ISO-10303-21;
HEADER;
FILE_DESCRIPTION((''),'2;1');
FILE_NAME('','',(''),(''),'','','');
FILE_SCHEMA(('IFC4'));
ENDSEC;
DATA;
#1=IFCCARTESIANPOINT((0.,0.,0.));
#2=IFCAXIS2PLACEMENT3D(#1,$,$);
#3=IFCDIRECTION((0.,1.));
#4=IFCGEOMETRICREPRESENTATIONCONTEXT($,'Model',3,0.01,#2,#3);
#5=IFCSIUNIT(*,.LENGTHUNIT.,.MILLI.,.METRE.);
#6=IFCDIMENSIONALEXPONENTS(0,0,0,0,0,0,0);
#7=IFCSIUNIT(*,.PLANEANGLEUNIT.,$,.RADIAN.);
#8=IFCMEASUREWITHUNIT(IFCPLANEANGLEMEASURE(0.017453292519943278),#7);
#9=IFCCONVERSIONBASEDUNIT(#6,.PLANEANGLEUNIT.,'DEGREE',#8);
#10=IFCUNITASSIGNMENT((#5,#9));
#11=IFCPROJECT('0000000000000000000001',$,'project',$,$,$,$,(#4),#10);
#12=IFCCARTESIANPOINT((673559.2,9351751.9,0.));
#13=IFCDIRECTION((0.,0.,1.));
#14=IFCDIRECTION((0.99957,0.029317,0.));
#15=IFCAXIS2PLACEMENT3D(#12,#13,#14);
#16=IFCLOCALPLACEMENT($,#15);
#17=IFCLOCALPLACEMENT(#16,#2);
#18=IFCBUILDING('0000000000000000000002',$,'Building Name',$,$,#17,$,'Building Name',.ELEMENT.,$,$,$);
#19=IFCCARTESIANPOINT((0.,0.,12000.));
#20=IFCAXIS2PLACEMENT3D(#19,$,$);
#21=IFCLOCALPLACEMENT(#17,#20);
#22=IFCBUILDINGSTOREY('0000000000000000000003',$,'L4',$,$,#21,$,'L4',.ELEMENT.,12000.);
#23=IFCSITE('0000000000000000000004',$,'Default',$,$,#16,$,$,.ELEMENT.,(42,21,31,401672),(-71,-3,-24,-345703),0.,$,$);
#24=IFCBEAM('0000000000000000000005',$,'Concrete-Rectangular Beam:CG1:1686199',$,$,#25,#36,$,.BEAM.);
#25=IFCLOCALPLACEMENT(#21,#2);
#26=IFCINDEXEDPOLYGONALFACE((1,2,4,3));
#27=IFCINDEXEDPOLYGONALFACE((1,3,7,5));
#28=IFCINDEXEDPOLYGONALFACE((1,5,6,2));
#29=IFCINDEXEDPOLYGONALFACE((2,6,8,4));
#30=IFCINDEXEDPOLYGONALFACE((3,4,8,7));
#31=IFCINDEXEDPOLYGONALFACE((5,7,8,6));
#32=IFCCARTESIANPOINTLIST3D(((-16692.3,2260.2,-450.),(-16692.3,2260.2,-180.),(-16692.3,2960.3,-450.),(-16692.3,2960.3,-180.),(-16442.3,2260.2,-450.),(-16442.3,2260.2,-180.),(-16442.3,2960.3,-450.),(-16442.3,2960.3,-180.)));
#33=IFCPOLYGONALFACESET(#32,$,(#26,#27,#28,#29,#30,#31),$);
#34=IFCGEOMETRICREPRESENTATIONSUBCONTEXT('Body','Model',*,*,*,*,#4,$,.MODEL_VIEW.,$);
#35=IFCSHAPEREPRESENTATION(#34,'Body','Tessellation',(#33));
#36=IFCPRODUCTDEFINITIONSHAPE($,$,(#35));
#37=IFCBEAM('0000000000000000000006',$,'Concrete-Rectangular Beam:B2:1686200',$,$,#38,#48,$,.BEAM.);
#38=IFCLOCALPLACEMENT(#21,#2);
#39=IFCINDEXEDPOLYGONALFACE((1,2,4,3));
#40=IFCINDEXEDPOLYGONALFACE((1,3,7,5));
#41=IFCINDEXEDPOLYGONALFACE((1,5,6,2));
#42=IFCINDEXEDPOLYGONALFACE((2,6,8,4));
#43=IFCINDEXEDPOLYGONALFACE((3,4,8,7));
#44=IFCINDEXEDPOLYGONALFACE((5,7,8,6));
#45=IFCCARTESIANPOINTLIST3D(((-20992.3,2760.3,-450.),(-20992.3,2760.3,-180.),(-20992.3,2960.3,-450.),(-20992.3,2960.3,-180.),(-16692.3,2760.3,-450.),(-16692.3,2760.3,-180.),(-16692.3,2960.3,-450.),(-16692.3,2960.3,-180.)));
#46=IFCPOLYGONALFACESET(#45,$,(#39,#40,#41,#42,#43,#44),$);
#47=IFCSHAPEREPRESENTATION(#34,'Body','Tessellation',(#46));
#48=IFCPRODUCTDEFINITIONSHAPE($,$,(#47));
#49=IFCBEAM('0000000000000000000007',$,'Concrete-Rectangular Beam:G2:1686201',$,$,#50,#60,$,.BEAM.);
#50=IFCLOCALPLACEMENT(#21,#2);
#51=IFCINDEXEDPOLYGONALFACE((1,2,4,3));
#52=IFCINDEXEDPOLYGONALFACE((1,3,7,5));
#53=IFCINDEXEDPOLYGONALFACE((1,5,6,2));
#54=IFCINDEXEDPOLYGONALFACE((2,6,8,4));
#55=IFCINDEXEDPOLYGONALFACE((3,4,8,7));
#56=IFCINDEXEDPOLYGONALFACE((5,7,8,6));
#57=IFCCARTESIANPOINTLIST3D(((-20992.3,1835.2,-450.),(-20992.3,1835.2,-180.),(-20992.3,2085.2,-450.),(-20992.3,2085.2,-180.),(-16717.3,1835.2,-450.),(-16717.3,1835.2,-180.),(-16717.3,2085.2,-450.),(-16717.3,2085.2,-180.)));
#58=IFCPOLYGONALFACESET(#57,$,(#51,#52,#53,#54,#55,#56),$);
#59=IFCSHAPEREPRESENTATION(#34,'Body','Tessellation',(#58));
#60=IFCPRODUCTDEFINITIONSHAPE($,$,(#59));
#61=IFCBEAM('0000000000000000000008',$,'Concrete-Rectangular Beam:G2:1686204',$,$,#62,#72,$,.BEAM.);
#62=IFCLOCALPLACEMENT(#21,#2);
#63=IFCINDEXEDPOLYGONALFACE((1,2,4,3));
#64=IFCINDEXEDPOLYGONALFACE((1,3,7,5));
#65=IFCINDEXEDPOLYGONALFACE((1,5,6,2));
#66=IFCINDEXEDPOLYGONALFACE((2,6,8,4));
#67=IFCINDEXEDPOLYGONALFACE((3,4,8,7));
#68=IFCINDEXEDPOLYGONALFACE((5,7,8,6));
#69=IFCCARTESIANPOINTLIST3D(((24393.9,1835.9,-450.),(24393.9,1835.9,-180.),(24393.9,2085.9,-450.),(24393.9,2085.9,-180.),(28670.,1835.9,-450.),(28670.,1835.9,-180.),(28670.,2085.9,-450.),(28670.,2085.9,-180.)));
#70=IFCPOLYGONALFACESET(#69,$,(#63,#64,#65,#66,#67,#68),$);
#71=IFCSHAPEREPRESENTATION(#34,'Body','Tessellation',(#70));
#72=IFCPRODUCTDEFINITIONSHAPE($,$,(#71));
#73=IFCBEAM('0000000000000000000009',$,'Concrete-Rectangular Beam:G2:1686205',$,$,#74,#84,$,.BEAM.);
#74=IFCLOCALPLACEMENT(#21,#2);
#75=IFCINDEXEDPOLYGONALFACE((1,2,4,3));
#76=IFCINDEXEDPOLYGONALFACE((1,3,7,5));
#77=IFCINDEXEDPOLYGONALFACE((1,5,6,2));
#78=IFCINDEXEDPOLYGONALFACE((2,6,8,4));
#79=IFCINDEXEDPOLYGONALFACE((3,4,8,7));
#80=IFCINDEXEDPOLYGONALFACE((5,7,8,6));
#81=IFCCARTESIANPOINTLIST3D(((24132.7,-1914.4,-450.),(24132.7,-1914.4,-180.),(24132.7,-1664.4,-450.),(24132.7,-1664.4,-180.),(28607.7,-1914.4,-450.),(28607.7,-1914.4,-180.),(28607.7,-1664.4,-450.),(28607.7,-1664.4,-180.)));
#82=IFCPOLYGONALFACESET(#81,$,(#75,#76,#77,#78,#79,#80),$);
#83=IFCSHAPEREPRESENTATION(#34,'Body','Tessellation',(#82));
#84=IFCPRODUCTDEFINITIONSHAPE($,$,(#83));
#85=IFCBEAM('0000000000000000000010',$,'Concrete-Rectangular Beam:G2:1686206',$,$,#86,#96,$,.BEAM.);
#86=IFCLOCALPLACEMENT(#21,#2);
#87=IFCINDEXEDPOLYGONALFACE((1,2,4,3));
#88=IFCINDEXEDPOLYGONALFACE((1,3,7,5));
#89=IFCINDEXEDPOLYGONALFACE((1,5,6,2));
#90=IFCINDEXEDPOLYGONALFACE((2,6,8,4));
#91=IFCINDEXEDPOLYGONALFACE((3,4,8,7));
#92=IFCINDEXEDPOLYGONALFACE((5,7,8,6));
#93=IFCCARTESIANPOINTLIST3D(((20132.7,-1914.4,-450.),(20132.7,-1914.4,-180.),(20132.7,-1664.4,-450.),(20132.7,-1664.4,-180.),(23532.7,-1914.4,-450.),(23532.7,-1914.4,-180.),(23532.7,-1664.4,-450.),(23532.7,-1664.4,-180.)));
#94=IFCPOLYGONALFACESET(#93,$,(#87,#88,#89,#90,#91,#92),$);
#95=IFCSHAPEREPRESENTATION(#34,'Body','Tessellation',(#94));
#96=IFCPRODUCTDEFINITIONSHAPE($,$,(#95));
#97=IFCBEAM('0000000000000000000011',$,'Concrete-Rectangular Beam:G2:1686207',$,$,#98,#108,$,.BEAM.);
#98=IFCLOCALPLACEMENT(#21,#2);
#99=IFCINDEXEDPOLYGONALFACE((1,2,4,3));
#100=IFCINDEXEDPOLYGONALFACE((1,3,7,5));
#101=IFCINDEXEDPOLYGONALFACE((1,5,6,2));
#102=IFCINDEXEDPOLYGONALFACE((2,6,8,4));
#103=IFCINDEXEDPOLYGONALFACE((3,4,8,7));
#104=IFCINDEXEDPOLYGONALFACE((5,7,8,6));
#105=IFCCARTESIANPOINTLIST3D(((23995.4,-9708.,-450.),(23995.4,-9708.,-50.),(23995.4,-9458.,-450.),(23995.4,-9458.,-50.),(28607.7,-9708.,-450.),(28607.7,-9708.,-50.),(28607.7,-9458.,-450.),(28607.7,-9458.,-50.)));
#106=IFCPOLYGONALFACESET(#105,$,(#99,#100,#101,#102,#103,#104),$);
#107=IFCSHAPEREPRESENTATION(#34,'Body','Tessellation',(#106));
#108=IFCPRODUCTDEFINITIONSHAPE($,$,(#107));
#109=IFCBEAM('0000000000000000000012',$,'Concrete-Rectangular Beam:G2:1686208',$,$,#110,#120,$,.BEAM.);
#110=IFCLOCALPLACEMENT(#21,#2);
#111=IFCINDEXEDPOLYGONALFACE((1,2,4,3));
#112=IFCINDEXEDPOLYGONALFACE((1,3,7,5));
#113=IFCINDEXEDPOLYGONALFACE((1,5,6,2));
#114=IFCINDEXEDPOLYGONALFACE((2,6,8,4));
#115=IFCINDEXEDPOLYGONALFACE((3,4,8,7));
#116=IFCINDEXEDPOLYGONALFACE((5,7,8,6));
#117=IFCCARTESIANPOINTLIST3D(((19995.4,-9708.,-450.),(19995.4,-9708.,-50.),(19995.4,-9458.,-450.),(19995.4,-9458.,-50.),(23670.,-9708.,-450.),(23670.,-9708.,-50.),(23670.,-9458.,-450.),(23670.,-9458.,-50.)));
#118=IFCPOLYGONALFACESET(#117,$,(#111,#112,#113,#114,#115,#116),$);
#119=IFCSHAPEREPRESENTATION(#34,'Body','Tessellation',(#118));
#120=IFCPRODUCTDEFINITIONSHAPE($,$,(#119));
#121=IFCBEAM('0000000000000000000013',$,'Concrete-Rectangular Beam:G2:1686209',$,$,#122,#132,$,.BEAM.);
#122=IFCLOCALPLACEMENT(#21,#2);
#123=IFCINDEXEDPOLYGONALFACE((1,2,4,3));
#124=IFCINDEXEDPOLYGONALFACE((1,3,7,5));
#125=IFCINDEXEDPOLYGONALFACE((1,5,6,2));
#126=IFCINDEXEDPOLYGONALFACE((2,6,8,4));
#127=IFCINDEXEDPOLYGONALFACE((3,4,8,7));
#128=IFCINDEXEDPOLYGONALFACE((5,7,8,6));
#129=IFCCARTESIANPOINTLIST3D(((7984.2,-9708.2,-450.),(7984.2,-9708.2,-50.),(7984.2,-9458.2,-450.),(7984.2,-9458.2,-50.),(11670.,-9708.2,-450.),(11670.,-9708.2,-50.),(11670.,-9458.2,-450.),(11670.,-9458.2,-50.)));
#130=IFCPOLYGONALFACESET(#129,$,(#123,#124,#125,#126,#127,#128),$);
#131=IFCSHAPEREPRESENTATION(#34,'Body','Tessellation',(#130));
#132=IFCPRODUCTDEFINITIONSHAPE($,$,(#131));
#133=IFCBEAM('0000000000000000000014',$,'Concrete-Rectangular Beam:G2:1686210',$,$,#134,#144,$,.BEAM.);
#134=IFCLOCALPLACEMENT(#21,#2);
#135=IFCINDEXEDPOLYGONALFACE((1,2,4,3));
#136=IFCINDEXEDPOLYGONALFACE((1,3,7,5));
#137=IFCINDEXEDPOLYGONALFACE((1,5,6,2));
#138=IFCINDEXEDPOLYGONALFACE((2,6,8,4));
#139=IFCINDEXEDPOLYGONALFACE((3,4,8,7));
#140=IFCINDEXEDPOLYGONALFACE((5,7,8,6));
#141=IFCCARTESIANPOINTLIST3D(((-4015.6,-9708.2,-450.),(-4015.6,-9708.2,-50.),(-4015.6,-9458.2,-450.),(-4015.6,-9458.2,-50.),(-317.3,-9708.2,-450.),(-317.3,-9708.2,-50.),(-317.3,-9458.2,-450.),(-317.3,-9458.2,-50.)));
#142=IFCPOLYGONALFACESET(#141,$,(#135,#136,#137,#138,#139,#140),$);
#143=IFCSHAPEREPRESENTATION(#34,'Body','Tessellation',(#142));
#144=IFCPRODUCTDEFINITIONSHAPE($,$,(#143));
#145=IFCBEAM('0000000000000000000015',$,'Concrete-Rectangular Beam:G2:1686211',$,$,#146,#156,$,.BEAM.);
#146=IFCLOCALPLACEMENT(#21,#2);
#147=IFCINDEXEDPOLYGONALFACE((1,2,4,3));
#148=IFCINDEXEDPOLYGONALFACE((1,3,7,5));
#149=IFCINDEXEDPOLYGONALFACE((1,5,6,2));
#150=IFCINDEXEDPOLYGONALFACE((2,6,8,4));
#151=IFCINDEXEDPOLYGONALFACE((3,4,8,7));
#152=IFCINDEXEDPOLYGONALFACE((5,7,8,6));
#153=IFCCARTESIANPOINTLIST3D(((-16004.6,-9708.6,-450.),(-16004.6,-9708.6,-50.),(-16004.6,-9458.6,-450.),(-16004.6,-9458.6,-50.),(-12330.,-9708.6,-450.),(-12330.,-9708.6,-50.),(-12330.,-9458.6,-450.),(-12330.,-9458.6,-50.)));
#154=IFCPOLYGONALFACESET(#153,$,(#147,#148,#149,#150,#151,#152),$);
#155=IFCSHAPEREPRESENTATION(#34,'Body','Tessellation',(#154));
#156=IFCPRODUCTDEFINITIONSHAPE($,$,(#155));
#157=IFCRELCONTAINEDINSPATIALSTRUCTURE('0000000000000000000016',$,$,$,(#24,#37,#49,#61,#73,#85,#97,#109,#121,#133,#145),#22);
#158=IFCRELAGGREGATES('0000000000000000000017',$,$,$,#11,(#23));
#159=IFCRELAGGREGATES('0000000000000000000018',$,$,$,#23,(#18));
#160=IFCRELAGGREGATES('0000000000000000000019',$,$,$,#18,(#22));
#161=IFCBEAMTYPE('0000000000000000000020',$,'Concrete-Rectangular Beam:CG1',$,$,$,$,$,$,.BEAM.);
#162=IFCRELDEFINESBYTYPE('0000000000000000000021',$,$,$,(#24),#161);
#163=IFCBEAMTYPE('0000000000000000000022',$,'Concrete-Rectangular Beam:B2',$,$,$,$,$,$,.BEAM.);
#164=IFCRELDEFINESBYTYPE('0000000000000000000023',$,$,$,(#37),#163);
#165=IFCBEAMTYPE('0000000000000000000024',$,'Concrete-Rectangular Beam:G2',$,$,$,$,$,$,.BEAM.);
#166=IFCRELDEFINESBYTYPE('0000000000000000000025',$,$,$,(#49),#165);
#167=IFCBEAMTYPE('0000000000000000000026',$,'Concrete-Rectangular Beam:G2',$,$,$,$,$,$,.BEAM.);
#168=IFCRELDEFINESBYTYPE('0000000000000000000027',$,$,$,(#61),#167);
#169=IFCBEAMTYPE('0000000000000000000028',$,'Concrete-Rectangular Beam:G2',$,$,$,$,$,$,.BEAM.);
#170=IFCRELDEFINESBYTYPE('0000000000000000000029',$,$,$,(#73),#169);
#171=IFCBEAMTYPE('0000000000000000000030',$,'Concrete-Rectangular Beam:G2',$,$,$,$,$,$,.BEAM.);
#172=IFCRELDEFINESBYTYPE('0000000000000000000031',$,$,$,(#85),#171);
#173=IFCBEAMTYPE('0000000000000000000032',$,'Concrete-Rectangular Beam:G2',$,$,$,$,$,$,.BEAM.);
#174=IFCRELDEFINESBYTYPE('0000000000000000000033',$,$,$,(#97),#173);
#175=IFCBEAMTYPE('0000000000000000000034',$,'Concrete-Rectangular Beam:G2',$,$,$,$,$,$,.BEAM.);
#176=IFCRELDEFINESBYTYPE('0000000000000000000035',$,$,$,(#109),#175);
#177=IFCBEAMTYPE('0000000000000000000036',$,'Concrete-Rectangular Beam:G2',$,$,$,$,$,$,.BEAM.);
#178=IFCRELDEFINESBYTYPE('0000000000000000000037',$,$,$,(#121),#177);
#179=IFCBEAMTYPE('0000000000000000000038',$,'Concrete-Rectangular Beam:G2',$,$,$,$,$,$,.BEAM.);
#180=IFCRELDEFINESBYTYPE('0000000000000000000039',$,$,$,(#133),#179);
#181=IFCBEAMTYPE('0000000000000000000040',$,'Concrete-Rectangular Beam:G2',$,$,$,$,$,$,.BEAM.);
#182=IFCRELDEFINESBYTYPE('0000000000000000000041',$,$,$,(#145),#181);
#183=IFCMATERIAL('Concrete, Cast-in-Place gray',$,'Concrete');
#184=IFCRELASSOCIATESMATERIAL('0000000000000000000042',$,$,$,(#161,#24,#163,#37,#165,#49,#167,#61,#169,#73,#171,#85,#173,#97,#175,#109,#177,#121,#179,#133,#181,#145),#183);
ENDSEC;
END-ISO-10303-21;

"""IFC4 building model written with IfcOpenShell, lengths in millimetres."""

from ifc_helpers import new_model, entity, si_unit, converted_unit, direction, frame, origin, place, context, subcontext, project, spatial, indexed_curve, outline, extrude, source, transform, mapped, material, type_object, type_shapes, element, save


model = new_model("IFC4")

# Units and contexts
model_context = context("Model", 3, precision=0.01, world=origin(), true_north=direction((0.0, 1.0)))
body_context = subcontext(model_context, "Body", "Model", "MODEL_VIEW")
ifc_project = project(units=[si_unit("LENGTHUNIT", "METRE", prefix="MILLI"), converted_unit("PLANEANGLEUNIT", "DEGREE", entity("IfcPlaneAngleMeasure", 0.017453292519943278), si_unit("PLANEANGLEUNIT", "RADIAN"), dimensions=[0, 0, 0, 0, 0, 0, 0])], contexts=[model_context])

# Site, building, storey
site_placement = place(None, frame((673559.2, 9351751.9, 0.0), z_axis=(0.0, 0.0, 1.0), x_axis=(0.99957, 0.029317, 0.0)))
site = spatial("IfcSite", under=ifc_project, at=site_placement, Name="Default", CompositionType="ELEMENT", RefLatitude=(42, 21, 31, 401672), RefLongitude=(-71, -3, -24, -345703), RefElevation=0.0)
building_placement = place(site_placement, origin())
building = spatial("IfcBuilding", under=site, at=building_placement, Name="Building Name", LongName="Building Name", CompositionType="ELEMENT")
storey_placement = place(building_placement, frame((0.0, 0.0, 12000.0)))
storey = spatial("IfcBuildingStorey", under=building, at=storey_placement, Name="L4", LongName="L4", CompositionType="ELEMENT", Elevation=12000.0)

# Shared definitions
ifc_material = material(Name="Concrete, Cast-in-Place gray", Category="Concrete")

# Beams
beam_type_1 = type_object("IfcBeamType", Name="Concrete-Rectangular Beam:CG1", PredefinedType="BEAM", material=ifc_material)
shared_shape_1 = source(origin(), body_context, "Body", "SweptSolid", [
    extrude(outline(indexed_curve([(-125.0, -135.0), (125.0, -135.0), (125.0, 135.0), (-125.0, 135.0), (-125.0, -135.0)], self_intersect=False)), frame((-16567.3, 2260.2, 11685.0), z_axis=(0.0, 1.0, 0.0), x_axis=(-1.0, 0.0, 0.0)), (0.0, 0.0, 1.0), 700.1),
])
type_shapes(beam_type_1, [shared_shape_1])
beam_1_placement = place(storey_placement, frame((0.0, 0.0, -12000.0)))
element("IfcBeam", 1, at=beam_1_placement, inside=storey, type_object=beam_type_1, material=ifc_material, Name="Concrete-Rectangular Beam:CG1:1686199", PredefinedType="BEAM", context=body_context, shape_type="MappedRepresentation", body=[
    mapped(shared_shape_1, transform((0.0, 0.0, 0.0), scale=1.0)),
])
beam_type_2 = type_object("IfcBeamType", Name="Concrete-Rectangular Beam:B2", PredefinedType="BEAM", material=ifc_material)
shared_shape_2 = source(origin(), body_context, "Body", "SweptSolid", [
    extrude(outline(indexed_curve([(-135.0, -100.0), (135.0, -100.0), (135.0, 100.0), (-135.0, 100.0), (-135.0, -100.0)], self_intersect=False)), frame((-20992.3, 2860.3, 11685.0), z_axis=(1.0, 0.0, 0.0), x_axis=(0.0, 0.0, -1.0)), (0.0, 0.0, 1.0), 4300.0),
])
type_shapes(beam_type_2, [shared_shape_2])
beam_2_placement = place(storey_placement, frame((0.0, 0.0, -12000.0)))
element("IfcBeam", 2, at=beam_2_placement, inside=storey, type_object=beam_type_2, material=ifc_material, Name="Concrete-Rectangular Beam:B2:1686200", PredefinedType="BEAM", context=body_context, shape_type="MappedRepresentation", body=[
    mapped(shared_shape_2, transform((0.0, 0.0, 0.0), scale=1.0)),
])
beam_type_3 = type_object("IfcBeamType", Name="Concrete-Rectangular Beam:G2", PredefinedType="BEAM", material=ifc_material)
shared_shape_3 = source(origin(), body_context, "Body", "SweptSolid", [
    extrude(outline(indexed_curve([(-135.0, -125.0), (135.0, -125.0), (135.0, 125.0), (-135.0, 125.0), (-135.0, -125.0)], self_intersect=False)), frame((-20992.3, 1960.2, 11685.0), z_axis=(1.0, 0.0, 0.0), x_axis=(0.0, 0.0, -1.0)), (0.0, 0.0, 1.0), 4275.0),
])
type_shapes(beam_type_3, [shared_shape_3])
beam_3_placement = place(storey_placement, frame((0.0, 0.0, -12000.0)))
element("IfcBeam", 3, at=beam_3_placement, inside=storey, type_object=beam_type_3, material=ifc_material, Name="Concrete-Rectangular Beam:G2:1686201", PredefinedType="BEAM", context=body_context, shape_type="MappedRepresentation", body=[
    mapped(shared_shape_3, transform((0.0, 0.0, 0.0), scale=1.0)),
])
beam_type_4 = type_object("IfcBeamType", Name="Concrete-Rectangular Beam:G2", PredefinedType="BEAM", material=ifc_material)
shared_shape_4 = source(origin(), body_context, "Body", "SweptSolid", [
    extrude(outline(indexed_curve([(-135.0, -125.0), (135.0, -125.0), (135.0, 125.0), (-135.0, 125.0), (-135.0, -125.0)], self_intersect=False)), frame((28670.0, 1960.9, 11685.0), z_axis=(-1.0, 0.0, 0.0), x_axis=(0.0, 0.0, -1.0)), (0.0, 0.0, 1.0), 4276.1),
])
type_shapes(beam_type_4, [shared_shape_4])
beam_4_placement = place(storey_placement, frame((0.0, 0.0, -12000.0)))
element("IfcBeam", 4, at=beam_4_placement, inside=storey, type_object=beam_type_4, material=ifc_material, Name="Concrete-Rectangular Beam:G2:1686204", PredefinedType="BEAM", context=body_context, shape_type="MappedRepresentation", body=[
    mapped(shared_shape_4, transform((0.0, 0.0, 0.0), scale=1.0)),
])
beam_type_5 = type_object("IfcBeamType", Name="Concrete-Rectangular Beam:G2", PredefinedType="BEAM", material=ifc_material)
shared_shape_5 = source(origin(), body_context, "Body", "SweptSolid", [
    extrude(outline(indexed_curve([(-135.0, -125.0), (135.0, -125.0), (135.0, 125.0), (-135.0, 125.0), (-135.0, -125.0)], self_intersect=False)), frame((28607.7, -1789.4, 11685.0), z_axis=(-1.0, 0.0, 0.0), x_axis=(0.0, 0.0, -1.0)), (0.0, 0.0, 1.0), 4475.0),
])
type_shapes(beam_type_5, [shared_shape_5])
beam_5_placement = place(storey_placement, frame((0.0, 0.0, -12000.0)))
element("IfcBeam", 5, at=beam_5_placement, inside=storey, type_object=beam_type_5, material=ifc_material, Name="Concrete-Rectangular Beam:G2:1686205", PredefinedType="BEAM", context=body_context, shape_type="MappedRepresentation", body=[
    mapped(shared_shape_5, transform((0.0, 0.0, 0.0), scale=1.0)),
])
beam_type_6 = type_object("IfcBeamType", Name="Concrete-Rectangular Beam:G2", PredefinedType="BEAM", material=ifc_material)
shared_shape_6 = source(origin(), body_context, "Body", "SweptSolid", [
    extrude(outline(indexed_curve([(-135.0, -125.0), (135.0, -125.0), (135.0, 125.0), (-135.0, 125.0), (-135.0, -125.0)], self_intersect=False)), frame((23532.7, -1789.4, 11685.0), z_axis=(-1.0, 0.0, 0.0), x_axis=(0.0, 0.0, -1.0)), (0.0, 0.0, 1.0), 3400.0),
])
type_shapes(beam_type_6, [shared_shape_6])
beam_6_placement = place(storey_placement, frame((0.0, 0.0, -12000.0)))
element("IfcBeam", 6, at=beam_6_placement, inside=storey, type_object=beam_type_6, material=ifc_material, Name="Concrete-Rectangular Beam:G2:1686206", PredefinedType="BEAM", context=body_context, shape_type="MappedRepresentation", body=[
    mapped(shared_shape_6, transform((0.0, 0.0, 0.0), scale=1.0)),
])
beam_type_7 = type_object("IfcBeamType", Name="Concrete-Rectangular Beam:G2", PredefinedType="BEAM", material=ifc_material)
shared_shape_7 = source(origin(), body_context, "Body", "SweptSolid", [
    extrude(outline(indexed_curve([(-200.0, -125.0), (200.0, -125.0), (200.0, 125.0), (-200.0, 125.0), (-200.0, -125.0)], self_intersect=False)), frame((28607.7, -9583.0, 11750.0), z_axis=(-1.0, 0.0, 0.0), x_axis=(0.0, 0.0, -1.0)), (0.0, 0.0, 1.0), 4612.3),
])
type_shapes(beam_type_7, [shared_shape_7])
beam_7_placement = place(storey_placement, frame((0.0, 0.0, -12000.0)))
element("IfcBeam", 7, at=beam_7_placement, inside=storey, type_object=beam_type_7, material=ifc_material, Name="Concrete-Rectangular Beam:G2:1686207", PredefinedType="BEAM", context=body_context, shape_type="MappedRepresentation", body=[
    mapped(shared_shape_7, transform((0.0, 0.0, 0.0), scale=1.0)),
])
beam_type_8 = type_object("IfcBeamType", Name="Concrete-Rectangular Beam:G2", PredefinedType="BEAM", material=ifc_material)
shared_shape_8 = source(origin(), body_context, "Body", "SweptSolid", [
    extrude(outline(indexed_curve([(-200.0, -125.0), (200.0, -125.0), (200.0, 125.0), (-200.0, 125.0), (-200.0, -125.0)], self_intersect=False)), frame((23670.0, -9583.0, 11750.0), z_axis=(-1.0, 0.0, 0.0), x_axis=(0.0, 0.0, -1.0)), (0.0, 0.0, 1.0), 3674.6),
])
type_shapes(beam_type_8, [shared_shape_8])
beam_8_placement = place(storey_placement, frame((0.0, 0.0, -12000.0)))
element("IfcBeam", 8, at=beam_8_placement, inside=storey, type_object=beam_type_8, material=ifc_material, Name="Concrete-Rectangular Beam:G2:1686208", PredefinedType="BEAM", context=body_context, shape_type="MappedRepresentation", body=[
    mapped(shared_shape_8, transform((0.0, 0.0, 0.0), scale=1.0)),
])
beam_type_9 = type_object("IfcBeamType", Name="Concrete-Rectangular Beam:G2", PredefinedType="BEAM", material=ifc_material)
shared_shape_9 = source(origin(), body_context, "Body", "SweptSolid", [
    extrude(outline(indexed_curve([(-200.0, -125.0), (200.0, -125.0), (200.0, 125.0), (-200.0, 125.0), (-200.0, -125.0)], self_intersect=False)), frame((11670.0, -9583.2, 11750.0), z_axis=(-1.0, 0.0, 0.0), x_axis=(0.0, 0.0, -1.0)), (0.0, 0.0, 1.0), 3685.8),
])
type_shapes(beam_type_9, [shared_shape_9])
beam_9_placement = place(storey_placement, frame((0.0, 0.0, -12000.0)))
element("IfcBeam", 9, at=beam_9_placement, inside=storey, type_object=beam_type_9, material=ifc_material, Name="Concrete-Rectangular Beam:G2:1686209", PredefinedType="BEAM", context=body_context, shape_type="MappedRepresentation", body=[
    mapped(shared_shape_9, transform((0.0, 0.0, 0.0), scale=1.0)),
])
beam_type_10 = type_object("IfcBeamType", Name="Concrete-Rectangular Beam:G2", PredefinedType="BEAM", material=ifc_material)
shared_shape_10 = source(origin(), body_context, "Body", "SweptSolid", [
    extrude(outline(indexed_curve([(-200.0, -125.0), (200.0, -125.0), (200.0, 125.0), (-200.0, 125.0), (-200.0, -125.0)], self_intersect=False)), frame((-317.3, -9583.2, 11750.0), z_axis=(-1.0, 0.0, 0.0), x_axis=(0.0, 0.0, -1.0)), (0.0, 0.0, 1.0), 3698.2),
])
type_shapes(beam_type_10, [shared_shape_10])
beam_10_placement = place(storey_placement, frame((0.0, 0.0, -12000.0)))
element("IfcBeam", 10, at=beam_10_placement, inside=storey, type_object=beam_type_10, material=ifc_material, Name="Concrete-Rectangular Beam:G2:1686210", PredefinedType="BEAM", context=body_context, shape_type="MappedRepresentation", body=[
    mapped(shared_shape_10, transform((0.0, 0.0, 0.0), scale=1.0)),
])
beam_type_11 = type_object("IfcBeamType", Name="Concrete-Rectangular Beam:G2", PredefinedType="BEAM", material=ifc_material)
shared_shape_11 = source(origin(), body_context, "Body", "SweptSolid", [
    extrude(outline(indexed_curve([(-200.0, -125.0), (200.0, -125.0), (200.0, 125.0), (-200.0, 125.0), (-200.0, -125.0)], self_intersect=False)), frame((-12330.0, -9583.6, 11750.0), z_axis=(-1.0, 0.0, 0.0), x_axis=(0.0, 0.0, -1.0)), (0.0, 0.0, 1.0), 3674.6),
])
type_shapes(beam_type_11, [shared_shape_11])
beam_11_placement = place(storey_placement, frame((0.0, 0.0, -12000.0)))
element("IfcBeam", 11, at=beam_11_placement, inside=storey, type_object=beam_type_11, material=ifc_material, Name="Concrete-Rectangular Beam:G2:1686211", PredefinedType="BEAM", context=body_context, shape_type="MappedRepresentation", body=[
    mapped(shared_shape_11, transform((0.0, 0.0, 0.0), scale=1.0)),
])

save(model, "model.ifc")
